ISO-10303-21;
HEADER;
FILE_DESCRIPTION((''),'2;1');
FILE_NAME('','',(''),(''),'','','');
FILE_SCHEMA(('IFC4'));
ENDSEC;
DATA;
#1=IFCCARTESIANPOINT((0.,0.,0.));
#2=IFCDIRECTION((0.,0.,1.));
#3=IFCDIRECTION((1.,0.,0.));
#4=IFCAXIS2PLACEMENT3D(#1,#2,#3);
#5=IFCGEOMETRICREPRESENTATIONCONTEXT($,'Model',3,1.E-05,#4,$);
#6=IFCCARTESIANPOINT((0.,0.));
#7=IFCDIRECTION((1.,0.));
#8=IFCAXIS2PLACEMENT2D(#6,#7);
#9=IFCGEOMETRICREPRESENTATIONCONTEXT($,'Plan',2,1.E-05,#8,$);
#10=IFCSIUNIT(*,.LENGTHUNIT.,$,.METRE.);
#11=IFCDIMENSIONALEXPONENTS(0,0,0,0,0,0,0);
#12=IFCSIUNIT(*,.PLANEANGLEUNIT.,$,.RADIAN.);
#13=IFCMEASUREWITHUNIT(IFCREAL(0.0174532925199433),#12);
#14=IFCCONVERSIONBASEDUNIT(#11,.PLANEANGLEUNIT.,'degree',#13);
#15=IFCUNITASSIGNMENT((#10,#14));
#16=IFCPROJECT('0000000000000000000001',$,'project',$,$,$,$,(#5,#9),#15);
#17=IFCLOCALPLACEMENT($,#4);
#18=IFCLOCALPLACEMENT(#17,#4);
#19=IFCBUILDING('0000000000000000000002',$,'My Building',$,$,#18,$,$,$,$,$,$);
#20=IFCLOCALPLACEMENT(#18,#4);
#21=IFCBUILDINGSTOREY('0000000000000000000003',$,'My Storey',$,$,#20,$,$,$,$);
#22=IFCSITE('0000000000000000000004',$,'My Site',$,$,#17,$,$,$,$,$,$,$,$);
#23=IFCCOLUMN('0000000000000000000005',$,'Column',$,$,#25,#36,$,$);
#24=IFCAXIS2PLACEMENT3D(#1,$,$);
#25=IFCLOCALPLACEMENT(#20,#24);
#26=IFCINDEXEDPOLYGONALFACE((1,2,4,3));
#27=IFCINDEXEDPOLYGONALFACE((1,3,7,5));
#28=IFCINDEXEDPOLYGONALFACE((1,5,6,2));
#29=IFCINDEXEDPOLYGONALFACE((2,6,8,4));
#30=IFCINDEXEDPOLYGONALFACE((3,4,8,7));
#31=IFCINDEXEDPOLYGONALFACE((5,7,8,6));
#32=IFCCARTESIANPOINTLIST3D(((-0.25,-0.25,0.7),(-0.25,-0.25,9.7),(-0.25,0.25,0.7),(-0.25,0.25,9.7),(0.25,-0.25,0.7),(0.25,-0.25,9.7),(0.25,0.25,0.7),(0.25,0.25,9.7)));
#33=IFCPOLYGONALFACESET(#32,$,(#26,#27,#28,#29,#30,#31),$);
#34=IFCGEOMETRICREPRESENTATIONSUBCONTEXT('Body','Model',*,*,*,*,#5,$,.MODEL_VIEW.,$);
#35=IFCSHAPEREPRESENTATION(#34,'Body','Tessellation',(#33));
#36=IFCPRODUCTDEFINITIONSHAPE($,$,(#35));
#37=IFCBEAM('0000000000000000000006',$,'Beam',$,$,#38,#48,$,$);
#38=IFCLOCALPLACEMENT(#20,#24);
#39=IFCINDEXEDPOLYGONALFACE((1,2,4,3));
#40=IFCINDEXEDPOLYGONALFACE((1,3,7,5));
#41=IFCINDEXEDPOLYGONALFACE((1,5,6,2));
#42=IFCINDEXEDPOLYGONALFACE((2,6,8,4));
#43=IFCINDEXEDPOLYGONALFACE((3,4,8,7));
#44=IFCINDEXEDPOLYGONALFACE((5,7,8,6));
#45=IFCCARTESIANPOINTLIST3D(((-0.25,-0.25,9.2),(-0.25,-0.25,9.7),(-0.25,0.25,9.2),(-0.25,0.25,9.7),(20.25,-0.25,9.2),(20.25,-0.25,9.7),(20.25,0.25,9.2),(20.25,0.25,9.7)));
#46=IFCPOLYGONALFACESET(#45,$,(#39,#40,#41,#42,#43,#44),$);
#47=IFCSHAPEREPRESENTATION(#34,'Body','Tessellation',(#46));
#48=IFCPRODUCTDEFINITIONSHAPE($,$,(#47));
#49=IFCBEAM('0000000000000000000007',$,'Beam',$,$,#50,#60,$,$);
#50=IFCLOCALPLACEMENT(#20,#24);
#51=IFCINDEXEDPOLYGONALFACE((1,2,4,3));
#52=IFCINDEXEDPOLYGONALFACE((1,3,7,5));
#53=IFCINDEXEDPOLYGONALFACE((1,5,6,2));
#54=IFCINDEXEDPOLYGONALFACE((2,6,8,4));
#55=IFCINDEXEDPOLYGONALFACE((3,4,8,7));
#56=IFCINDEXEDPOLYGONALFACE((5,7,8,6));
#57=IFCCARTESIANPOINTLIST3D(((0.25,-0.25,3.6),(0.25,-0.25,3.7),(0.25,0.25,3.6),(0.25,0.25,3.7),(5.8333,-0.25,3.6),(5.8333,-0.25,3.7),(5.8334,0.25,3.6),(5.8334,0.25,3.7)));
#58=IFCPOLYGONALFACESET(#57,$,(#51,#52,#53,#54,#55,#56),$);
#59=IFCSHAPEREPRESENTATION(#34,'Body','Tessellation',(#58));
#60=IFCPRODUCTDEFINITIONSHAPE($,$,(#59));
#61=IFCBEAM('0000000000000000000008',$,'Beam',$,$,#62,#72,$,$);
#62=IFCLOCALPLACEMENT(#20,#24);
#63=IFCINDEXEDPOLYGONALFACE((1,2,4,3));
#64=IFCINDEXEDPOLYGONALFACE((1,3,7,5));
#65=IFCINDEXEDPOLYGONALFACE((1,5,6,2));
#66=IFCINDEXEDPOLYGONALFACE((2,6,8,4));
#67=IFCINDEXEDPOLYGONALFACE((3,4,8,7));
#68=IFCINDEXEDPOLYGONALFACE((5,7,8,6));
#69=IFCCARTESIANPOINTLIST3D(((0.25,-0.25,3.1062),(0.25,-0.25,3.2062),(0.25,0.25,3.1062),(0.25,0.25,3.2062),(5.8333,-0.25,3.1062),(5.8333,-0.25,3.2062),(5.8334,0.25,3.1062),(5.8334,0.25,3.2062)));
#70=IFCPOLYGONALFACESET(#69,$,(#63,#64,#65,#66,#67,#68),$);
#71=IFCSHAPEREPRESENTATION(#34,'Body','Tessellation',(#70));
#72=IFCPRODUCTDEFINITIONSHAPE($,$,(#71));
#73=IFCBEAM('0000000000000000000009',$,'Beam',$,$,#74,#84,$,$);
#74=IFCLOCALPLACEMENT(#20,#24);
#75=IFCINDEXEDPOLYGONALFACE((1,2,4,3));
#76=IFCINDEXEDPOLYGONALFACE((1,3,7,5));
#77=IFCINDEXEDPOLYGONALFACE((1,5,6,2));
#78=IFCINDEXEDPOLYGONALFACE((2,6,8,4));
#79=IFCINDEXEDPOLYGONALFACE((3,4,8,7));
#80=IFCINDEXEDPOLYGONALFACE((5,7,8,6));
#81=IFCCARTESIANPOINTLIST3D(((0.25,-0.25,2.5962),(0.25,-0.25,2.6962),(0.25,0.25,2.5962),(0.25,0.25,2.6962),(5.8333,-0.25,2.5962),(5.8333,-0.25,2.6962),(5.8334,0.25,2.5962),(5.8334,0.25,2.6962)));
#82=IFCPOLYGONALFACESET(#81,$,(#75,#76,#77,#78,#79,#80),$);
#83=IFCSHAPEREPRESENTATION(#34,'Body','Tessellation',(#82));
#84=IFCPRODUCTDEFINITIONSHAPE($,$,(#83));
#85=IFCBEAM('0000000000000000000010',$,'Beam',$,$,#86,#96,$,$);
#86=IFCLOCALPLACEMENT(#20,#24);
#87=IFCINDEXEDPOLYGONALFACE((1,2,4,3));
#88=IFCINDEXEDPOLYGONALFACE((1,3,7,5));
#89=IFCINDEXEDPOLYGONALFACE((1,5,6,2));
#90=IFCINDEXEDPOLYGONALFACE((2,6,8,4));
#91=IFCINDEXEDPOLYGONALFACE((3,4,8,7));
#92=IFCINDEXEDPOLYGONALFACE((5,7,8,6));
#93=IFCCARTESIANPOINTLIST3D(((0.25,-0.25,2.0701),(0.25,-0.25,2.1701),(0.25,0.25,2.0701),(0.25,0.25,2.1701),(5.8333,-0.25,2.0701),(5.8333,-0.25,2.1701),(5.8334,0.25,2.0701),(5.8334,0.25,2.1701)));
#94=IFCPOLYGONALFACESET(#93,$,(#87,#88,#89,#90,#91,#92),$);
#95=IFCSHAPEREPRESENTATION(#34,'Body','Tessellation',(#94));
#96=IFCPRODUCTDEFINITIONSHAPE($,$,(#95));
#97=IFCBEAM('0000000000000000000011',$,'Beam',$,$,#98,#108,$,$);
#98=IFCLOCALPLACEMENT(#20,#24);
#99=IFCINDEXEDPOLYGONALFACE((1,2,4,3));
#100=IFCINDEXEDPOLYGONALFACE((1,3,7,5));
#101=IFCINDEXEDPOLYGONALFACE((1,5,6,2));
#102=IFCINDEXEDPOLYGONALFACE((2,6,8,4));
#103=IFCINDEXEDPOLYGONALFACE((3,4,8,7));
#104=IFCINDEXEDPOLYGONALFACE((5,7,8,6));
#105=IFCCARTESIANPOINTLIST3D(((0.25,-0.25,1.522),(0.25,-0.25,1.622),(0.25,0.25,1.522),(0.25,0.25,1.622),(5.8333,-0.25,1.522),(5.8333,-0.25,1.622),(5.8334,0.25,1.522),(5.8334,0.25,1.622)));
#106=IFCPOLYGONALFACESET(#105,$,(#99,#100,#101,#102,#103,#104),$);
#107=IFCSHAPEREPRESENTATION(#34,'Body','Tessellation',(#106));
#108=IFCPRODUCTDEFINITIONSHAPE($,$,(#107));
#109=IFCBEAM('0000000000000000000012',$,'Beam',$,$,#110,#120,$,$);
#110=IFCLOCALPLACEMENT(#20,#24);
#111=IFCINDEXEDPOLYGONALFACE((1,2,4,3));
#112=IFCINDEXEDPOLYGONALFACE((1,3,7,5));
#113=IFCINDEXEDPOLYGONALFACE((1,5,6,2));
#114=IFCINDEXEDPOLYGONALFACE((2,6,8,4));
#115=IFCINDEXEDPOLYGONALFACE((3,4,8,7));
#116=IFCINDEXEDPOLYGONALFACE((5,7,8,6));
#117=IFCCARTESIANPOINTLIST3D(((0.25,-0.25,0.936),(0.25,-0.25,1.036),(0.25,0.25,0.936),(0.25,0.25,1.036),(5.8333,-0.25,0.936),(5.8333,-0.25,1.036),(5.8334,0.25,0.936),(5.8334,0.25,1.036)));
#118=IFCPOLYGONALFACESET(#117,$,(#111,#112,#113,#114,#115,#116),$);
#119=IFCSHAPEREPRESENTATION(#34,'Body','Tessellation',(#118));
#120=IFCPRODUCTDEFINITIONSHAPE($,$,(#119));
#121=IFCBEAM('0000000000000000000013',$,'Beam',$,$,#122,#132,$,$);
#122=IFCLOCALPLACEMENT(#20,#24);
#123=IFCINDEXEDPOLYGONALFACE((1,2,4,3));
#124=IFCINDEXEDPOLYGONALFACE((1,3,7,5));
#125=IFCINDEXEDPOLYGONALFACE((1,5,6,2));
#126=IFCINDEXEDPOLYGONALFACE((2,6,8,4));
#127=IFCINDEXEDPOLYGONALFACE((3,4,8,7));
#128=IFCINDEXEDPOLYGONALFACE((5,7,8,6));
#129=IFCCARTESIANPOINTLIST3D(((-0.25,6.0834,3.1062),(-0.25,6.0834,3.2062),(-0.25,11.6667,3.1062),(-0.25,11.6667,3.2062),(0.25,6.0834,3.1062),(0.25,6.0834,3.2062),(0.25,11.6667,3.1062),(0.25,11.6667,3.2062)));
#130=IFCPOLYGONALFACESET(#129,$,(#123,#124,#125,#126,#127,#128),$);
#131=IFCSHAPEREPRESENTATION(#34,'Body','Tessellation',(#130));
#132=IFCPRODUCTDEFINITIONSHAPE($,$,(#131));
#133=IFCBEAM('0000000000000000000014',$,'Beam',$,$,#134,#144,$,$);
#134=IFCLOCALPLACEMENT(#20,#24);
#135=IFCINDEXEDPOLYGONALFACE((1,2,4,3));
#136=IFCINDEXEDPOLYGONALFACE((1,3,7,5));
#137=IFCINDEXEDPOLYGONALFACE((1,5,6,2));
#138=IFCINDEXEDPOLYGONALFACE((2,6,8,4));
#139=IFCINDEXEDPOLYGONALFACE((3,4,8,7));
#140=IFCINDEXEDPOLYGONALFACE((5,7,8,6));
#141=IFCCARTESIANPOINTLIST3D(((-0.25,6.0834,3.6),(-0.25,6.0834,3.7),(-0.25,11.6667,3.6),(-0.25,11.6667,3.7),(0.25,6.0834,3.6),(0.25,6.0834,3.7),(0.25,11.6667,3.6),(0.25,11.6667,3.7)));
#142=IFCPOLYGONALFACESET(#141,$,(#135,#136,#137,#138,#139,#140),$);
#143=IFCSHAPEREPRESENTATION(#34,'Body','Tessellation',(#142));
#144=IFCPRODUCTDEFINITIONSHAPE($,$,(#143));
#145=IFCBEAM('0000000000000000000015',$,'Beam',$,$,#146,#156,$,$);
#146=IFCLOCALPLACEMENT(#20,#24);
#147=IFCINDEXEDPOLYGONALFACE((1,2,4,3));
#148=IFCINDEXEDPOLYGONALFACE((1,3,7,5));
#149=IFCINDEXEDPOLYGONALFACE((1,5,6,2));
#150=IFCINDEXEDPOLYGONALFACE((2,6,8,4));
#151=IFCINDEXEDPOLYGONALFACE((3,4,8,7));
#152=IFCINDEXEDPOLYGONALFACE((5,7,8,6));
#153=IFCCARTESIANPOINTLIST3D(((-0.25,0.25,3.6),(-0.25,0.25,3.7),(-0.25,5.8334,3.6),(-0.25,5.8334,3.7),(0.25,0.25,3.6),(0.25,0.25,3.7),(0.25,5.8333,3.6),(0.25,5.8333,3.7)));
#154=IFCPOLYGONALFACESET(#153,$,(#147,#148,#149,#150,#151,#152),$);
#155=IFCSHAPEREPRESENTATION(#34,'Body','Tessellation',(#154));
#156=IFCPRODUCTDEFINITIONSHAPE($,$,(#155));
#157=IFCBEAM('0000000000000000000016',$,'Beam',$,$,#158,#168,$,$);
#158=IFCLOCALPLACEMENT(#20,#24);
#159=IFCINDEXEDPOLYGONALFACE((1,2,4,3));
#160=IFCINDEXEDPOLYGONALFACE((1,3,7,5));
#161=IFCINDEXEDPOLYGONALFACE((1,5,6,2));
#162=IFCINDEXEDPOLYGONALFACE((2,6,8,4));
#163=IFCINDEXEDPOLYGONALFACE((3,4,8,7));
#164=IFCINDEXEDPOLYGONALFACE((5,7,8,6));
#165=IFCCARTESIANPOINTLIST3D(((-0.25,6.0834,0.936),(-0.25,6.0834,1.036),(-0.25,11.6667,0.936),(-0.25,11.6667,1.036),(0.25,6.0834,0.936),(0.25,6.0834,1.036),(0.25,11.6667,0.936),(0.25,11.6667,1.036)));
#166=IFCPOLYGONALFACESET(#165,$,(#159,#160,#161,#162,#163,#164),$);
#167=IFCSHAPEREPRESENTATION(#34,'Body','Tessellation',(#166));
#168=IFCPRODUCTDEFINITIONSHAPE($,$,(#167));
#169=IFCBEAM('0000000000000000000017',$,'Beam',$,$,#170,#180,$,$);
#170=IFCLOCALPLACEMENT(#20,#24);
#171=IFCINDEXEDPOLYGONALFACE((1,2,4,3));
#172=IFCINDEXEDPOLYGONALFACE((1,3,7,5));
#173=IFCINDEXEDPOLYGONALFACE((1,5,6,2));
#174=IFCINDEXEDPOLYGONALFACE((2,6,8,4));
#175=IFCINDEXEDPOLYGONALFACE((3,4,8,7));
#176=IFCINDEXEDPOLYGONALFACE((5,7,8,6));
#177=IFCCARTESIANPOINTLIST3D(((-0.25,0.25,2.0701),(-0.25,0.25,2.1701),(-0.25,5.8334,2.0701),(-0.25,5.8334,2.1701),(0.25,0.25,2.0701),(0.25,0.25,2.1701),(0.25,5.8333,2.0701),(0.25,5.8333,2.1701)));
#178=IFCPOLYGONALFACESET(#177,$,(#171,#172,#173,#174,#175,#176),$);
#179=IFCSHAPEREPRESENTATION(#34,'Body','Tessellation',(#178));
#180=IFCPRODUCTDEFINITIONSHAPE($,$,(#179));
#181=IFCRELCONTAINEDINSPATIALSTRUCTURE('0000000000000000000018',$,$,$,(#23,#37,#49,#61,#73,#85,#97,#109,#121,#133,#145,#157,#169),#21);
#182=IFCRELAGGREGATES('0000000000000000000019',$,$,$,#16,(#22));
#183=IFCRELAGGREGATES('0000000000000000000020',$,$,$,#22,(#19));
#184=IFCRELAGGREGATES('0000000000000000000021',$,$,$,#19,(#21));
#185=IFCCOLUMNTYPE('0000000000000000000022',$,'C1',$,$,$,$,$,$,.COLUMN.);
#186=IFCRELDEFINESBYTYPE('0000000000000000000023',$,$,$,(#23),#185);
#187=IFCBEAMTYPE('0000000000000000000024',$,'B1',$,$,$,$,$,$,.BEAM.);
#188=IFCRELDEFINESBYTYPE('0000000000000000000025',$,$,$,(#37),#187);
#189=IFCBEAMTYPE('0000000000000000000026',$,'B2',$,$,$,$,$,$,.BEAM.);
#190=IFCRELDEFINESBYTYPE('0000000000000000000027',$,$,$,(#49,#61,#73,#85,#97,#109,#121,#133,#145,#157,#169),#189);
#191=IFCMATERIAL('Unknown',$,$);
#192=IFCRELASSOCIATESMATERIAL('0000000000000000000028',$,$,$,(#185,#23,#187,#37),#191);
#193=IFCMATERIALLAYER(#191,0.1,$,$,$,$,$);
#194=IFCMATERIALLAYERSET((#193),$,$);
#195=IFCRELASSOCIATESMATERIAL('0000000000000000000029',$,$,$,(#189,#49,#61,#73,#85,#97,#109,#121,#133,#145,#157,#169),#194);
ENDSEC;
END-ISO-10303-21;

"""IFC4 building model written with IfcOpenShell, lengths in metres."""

from ifc_helpers import new_model, entity, si_unit, converted_unit, frame, origin_with_axes, origin_2d_with_axis, place, context, subcontext, project, spatial, indexed_curve, rectangle, outline, extrude, material, layer, layer_set, layer_usage, material_profile, profile_set, profile_usage, type_object, element, save


model = new_model("IFC4")

# Units and contexts
model_context = context("Model", 3, precision=1e-05, world=origin_with_axes())
plan_context = context("Plan", 2, precision=1e-05, world=origin_2d_with_axis())
body_context = subcontext(model_context, "Body", "Model", "MODEL_VIEW")
ifc_project = project(units=[si_unit("LENGTHUNIT", "METRE"), converted_unit("PLANEANGLEUNIT", "degree", entity("IfcReal", 0.0174532925199433), si_unit("PLANEANGLEUNIT", "RADIAN"), dimensions=[0, 0, 0, 0, 0, 0, 0])], contexts=[model_context, plan_context])

# Site, building, storey
site_placement = place(None, origin_with_axes())
site = spatial("IfcSite", under=ifc_project, at=site_placement, Name="My Site")
building_placement = place(site_placement, origin_with_axes())
building = spatial("IfcBuilding", under=site, at=building_placement, Name="My Building")
storey_placement = place(building_placement, origin_with_axes())
storey = spatial("IfcBuildingStorey", under=building, at=storey_placement, Name="My Storey")

# Column
ifc_material = material(Name="Unknown")
ifc_material_profile_1 = material_profile(ifc_material, rectangle(XDim=0.5, YDim=0.5))
ifc_profile_set_1 = profile_set([ifc_material_profile_1])
ifc_profile_usage_1 = profile_usage(ifc_profile_set_1, cardinal=5)
column_type = type_object("IfcColumnType", Name="C1", PredefinedType="COLUMN", material=ifc_profile_set_1)
column_placement = place(storey_placement, frame((0.0, 0.0, 0.7), z_axis=(0.0, 0.0, 1.0), x_axis=(1.0, 0.0, 0.0)))
element("IfcColumn", 1, at=column_placement, inside=storey, type_object=column_type, material=ifc_profile_usage_1, Name="Column", context=body_context, shape_type="SweptSolid", body=[
    extrude(rectangle(XDim=0.5, YDim=0.5), origin_with_axes(), (0.0, 0.0, 1.0), 9.0),
])

# Beams
ifc_material_profile_2 = material_profile(ifc_material, rectangle(XDim=0.5, YDim=0.5))
ifc_profile_set_2 = profile_set([ifc_material_profile_2])
ifc_profile_usage_2 = profile_usage(ifc_profile_set_2, cardinal=8)
beam_type_1 = type_object("IfcBeamType", Name="B1", PredefinedType="BEAM", material=ifc_profile_set_2)
beam_1_placement = place(storey_placement, frame((-0.25, 0.0, 9.7), z_axis=(1.0, -0.000001, 0.000001), x_axis=(0.000001, 1.0, 0.0)))
element("IfcBeam", 2, at=beam_1_placement, inside=storey, type_object=beam_type_1, material=ifc_profile_usage_2, Name="Beam", context=body_context, shape_type="SweptSolid", body=[
    extrude(rectangle(XDim=0.5, YDim=0.5), frame((0.0, -0.25, 0.0), z_axis=(0.0, 0.0, 1.0), x_axis=(1.0, 0.0, 0.0)), (0.0, 0.0, 1.0), 20.5),
])
ifc_layer_1 = layer(ifc_material, 0.1)
ifc_layer_set_1 = layer_set([ifc_layer_1])
ifc_layer_usage_1 = layer_usage(ifc_layer_set_1, "AXIS3", "POSITIVE", -0.1)
beam_type_2 = type_object("IfcBeamType", Name="B2", PredefinedType="BEAM", material=ifc_layer_set_1)
beam_2_placement = place(storey_placement, frame((0.25, 0.25, 3.7), z_axis=(0.0, 0.0, 1.0), x_axis=(1.0, 0.0, 0.0)))
element("IfcBeam", 3, at=beam_2_placement, inside=storey, type_object=beam_type_2, material=ifc_layer_usage_1, Name="Beam", context=body_context, shape_type="SweptSolid", body=[
    extrude(outline(indexed_curve([(0.0, 0.0), (0.0, -0.5), (5.5833, -0.5), (5.5834, 0.0), (0.0, 0.0)])), frame((0.0, 0.0, -0.1), z_axis=(0.0, 0.0, 1.0), x_axis=(1.0, 0.0, 0.0)), (0.0, 0.0, 1.0), 0.1),
])
ifc_layer_usage_2 = layer_usage(ifc_layer_set_1, "AXIS3", "POSITIVE", -0.1)
beam_3_placement = place(storey_placement, frame((0.25, 0.25, 3.2062), z_axis=(0.0, 0.0, 1.0), x_axis=(1.0, 0.0, 0.0)))
element("IfcBeam", 4, at=beam_3_placement, inside=storey, type_object=beam_type_2, material=ifc_layer_usage_2, Name="Beam", context=body_context, shape_type="SweptSolid", body=[
    extrude(outline(indexed_curve([(0.0, 0.0), (0.0, -0.5), (5.5833, -0.5), (5.5834, 0.0), (0.0, 0.0)])), frame((0.0, 0.0, -0.1), z_axis=(0.0, 0.0, 1.0), x_axis=(1.0, 0.0, 0.0)), (0.0, 0.0, 1.0), 0.1),
])
ifc_layer_usage_3 = layer_usage(ifc_layer_set_1, "AXIS3", "POSITIVE", -0.1)
beam_4_placement = place(storey_placement, frame((0.25, 0.25, 2.6962), z_axis=(0.0, 0.0, 1.0), x_axis=(1.0, 0.0, 0.0)))
element("IfcBeam", 5, at=beam_4_placement, inside=storey, type_object=beam_type_2, material=ifc_layer_usage_3, Name="Beam", context=body_context, shape_type="SweptSolid", body=[
    extrude(outline(indexed_curve([(0.0, 0.0), (0.0, -0.5), (5.5833, -0.5), (5.5834, 0.0), (0.0, 0.0)])), frame((0.0, 0.0, -0.1), z_axis=(0.0, 0.0, 1.0), x_axis=(1.0, 0.0, 0.0)), (0.0, 0.0, 1.0), 0.1),
])
ifc_layer_usage_4 = layer_usage(ifc_layer_set_1, "AXIS3", "POSITIVE", -0.1)
beam_5_placement = place(storey_placement, frame((0.25, 0.25, 2.1701), z_axis=(0.0, 0.0, 1.0), x_axis=(1.0, 0.0, 0.0)))
element("IfcBeam", 6, at=beam_5_placement, inside=storey, type_object=beam_type_2, material=ifc_layer_usage_4, Name="Beam", context=body_context, shape_type="SweptSolid", body=[
    extrude(outline(indexed_curve([(0.0, 0.0), (0.0, -0.5), (5.5833, -0.5), (5.5834, 0.0), (0.0, 0.0)])), frame((0.0, 0.0, -0.1), z_axis=(0.0, 0.0, 1.0), x_axis=(1.0, 0.0, 0.0)), (0.0, 0.0, 1.0), 0.1),
])
ifc_layer_usage_5 = layer_usage(ifc_layer_set_1, "AXIS3", "POSITIVE", -0.1)
beam_6_placement = place(storey_placement, frame((0.25, 0.25, 1.622), z_axis=(0.0, 0.0, 1.0), x_axis=(1.0, 0.0, 0.0)))
element("IfcBeam", 7, at=beam_6_placement, inside=storey, type_object=beam_type_2, material=ifc_layer_usage_5, Name="Beam", context=body_context, shape_type="SweptSolid", body=[
    extrude(outline(indexed_curve([(0.0, 0.0), (0.0, -0.5), (5.5833, -0.5), (5.5834, 0.0), (0.0, 0.0)])), frame((0.0, 0.0, -0.1), z_axis=(0.0, 0.0, 1.0), x_axis=(1.0, 0.0, 0.0)), (0.0, 0.0, 1.0), 0.1),
])
ifc_layer_usage_6 = layer_usage(ifc_layer_set_1, "AXIS3", "POSITIVE", -0.1)
beam_7_placement = place(storey_placement, frame((0.25, 0.25, 1.036), z_axis=(0.0, 0.0, 1.0), x_axis=(1.0, 0.0, 0.0)))
element("IfcBeam", 8, at=beam_7_placement, inside=storey, type_object=beam_type_2, material=ifc_layer_usage_6, Name="Beam", context=body_context, shape_type="SweptSolid", body=[
    extrude(outline(indexed_curve([(0.0, 0.0), (0.0, -0.5), (5.5833, -0.5), (5.5834, 0.0), (0.0, 0.0)])), frame((0.0, 0.0, -0.1), z_axis=(0.0, 0.0, 1.0), x_axis=(1.0, 0.0, 0.0)), (0.0, 0.0, 1.0), 0.1),
])
ifc_layer_usage_7 = layer_usage(ifc_layer_set_1, "AXIS3", "POSITIVE", -0.1)
beam_8_placement = place(storey_placement, frame((-0.25, 6.0834, 3.2062), z_axis=(0.0, 0.0, 1.0), x_axis=(0.0, 1.0, 0.0)))
element("IfcBeam", 9, at=beam_8_placement, inside=storey, type_object=beam_type_2, material=ifc_layer_usage_7, Name="Beam", context=body_context, shape_type="SweptSolid", body=[
    extrude(outline(indexed_curve([(0.0, 0.0), (0.0, -0.5), (5.5833, -0.5), (5.5834, 0.0), (0.0, 0.0)])), frame((0.0, 0.0, -0.1), z_axis=(0.0, 0.0, 1.0), x_axis=(1.0, 0.0, 0.0)), (0.0, 0.0, 1.0), 0.1),
])
ifc_layer_usage_8 = layer_usage(ifc_layer_set_1, "AXIS3", "POSITIVE", -0.1)
beam_9_placement = place(storey_placement, frame((-0.25, 6.0834, 3.7), z_axis=(0.0, 0.0, 1.0), x_axis=(0.0, 1.0, 0.0)))
element("IfcBeam", 10, at=beam_9_placement, inside=storey, type_object=beam_type_2, material=ifc_layer_usage_8, Name="Beam", context=body_context, shape_type="SweptSolid", body=[
    extrude(outline(indexed_curve([(0.0, 0.0), (0.0, -0.5), (5.5833, -0.5), (5.5834, 0.0), (0.0, 0.0)])), frame((0.0, 0.0, -0.1), z_axis=(0.0, 0.0, 1.0), x_axis=(1.0, 0.0, 0.0)), (0.0, 0.0, 1.0), 0.1),
])
ifc_layer_usage_9 = layer_usage(ifc_layer_set_1, "AXIS3", "POSITIVE", -0.1)
beam_10_placement = place(storey_placement, frame((-0.25, 0.25, 3.7), z_axis=(0.0, 0.0, 1.0), x_axis=(0.0, 1.0, 0.0)))
element("IfcBeam", 11, at=beam_10_placement, inside=storey, type_object=beam_type_2, material=ifc_layer_usage_9, Name="Beam", context=body_context, shape_type="SweptSolid", body=[
    extrude(outline(indexed_curve([(0.0, 0.0), (0.0, -0.5), (5.5833, -0.5), (5.5834, 0.0), (0.0, 0.0)])), frame((0.0, 0.0, -0.1), z_axis=(0.0, 0.0, 1.0), x_axis=(1.0, 0.0, 0.0)), (0.0, 0.0, 1.0), 0.1),
])
ifc_layer_usage_10 = layer_usage(ifc_layer_set_1, "AXIS3", "POSITIVE", -0.1)
beam_11_placement = place(storey_placement, frame((-0.25, 6.0834, 1.036), z_axis=(0.0, 0.0, 1.0), x_axis=(0.0, 1.0, 0.0)))
element("IfcBeam", 12, at=beam_11_placement, inside=storey, type_object=beam_type_2, material=ifc_layer_usage_10, Name="Beam", context=body_context, shape_type="SweptSolid", body=[
    extrude(outline(indexed_curve([(0.0, 0.0), (0.0, -0.5), (5.5833, -0.5), (5.5834, 0.0), (0.0, 0.0)])), frame((0.0, 0.0, -0.1), z_axis=(0.0, 0.0, 1.0), x_axis=(1.0, 0.0, 0.0)), (0.0, 0.0, 1.0), 0.1),
])
ifc_layer_usage_11 = layer_usage(ifc_layer_set_1, "AXIS3", "POSITIVE", -0.1)
beam_12_placement = place(storey_placement, frame((-0.25, 0.25, 2.1701), z_axis=(0.0, 0.0, 1.0), x_axis=(0.0, 1.0, 0.0)))
element("IfcBeam", 13, at=beam_12_placement, inside=storey, type_object=beam_type_2, material=ifc_layer_usage_11, Name="Beam", context=body_context, shape_type="SweptSolid", body=[
    extrude(outline(indexed_curve([(0.0, 0.0), (0.0, -0.5), (5.5833, -0.5), (5.5834, 0.0), (0.0, 0.0)])), frame((0.0, 0.0, -0.1), z_axis=(0.0, 0.0, 1.0), x_axis=(1.0, 0.0, 0.0)), (0.0, 0.0, 1.0), 0.1),
])

save(model, "model.ifc")
